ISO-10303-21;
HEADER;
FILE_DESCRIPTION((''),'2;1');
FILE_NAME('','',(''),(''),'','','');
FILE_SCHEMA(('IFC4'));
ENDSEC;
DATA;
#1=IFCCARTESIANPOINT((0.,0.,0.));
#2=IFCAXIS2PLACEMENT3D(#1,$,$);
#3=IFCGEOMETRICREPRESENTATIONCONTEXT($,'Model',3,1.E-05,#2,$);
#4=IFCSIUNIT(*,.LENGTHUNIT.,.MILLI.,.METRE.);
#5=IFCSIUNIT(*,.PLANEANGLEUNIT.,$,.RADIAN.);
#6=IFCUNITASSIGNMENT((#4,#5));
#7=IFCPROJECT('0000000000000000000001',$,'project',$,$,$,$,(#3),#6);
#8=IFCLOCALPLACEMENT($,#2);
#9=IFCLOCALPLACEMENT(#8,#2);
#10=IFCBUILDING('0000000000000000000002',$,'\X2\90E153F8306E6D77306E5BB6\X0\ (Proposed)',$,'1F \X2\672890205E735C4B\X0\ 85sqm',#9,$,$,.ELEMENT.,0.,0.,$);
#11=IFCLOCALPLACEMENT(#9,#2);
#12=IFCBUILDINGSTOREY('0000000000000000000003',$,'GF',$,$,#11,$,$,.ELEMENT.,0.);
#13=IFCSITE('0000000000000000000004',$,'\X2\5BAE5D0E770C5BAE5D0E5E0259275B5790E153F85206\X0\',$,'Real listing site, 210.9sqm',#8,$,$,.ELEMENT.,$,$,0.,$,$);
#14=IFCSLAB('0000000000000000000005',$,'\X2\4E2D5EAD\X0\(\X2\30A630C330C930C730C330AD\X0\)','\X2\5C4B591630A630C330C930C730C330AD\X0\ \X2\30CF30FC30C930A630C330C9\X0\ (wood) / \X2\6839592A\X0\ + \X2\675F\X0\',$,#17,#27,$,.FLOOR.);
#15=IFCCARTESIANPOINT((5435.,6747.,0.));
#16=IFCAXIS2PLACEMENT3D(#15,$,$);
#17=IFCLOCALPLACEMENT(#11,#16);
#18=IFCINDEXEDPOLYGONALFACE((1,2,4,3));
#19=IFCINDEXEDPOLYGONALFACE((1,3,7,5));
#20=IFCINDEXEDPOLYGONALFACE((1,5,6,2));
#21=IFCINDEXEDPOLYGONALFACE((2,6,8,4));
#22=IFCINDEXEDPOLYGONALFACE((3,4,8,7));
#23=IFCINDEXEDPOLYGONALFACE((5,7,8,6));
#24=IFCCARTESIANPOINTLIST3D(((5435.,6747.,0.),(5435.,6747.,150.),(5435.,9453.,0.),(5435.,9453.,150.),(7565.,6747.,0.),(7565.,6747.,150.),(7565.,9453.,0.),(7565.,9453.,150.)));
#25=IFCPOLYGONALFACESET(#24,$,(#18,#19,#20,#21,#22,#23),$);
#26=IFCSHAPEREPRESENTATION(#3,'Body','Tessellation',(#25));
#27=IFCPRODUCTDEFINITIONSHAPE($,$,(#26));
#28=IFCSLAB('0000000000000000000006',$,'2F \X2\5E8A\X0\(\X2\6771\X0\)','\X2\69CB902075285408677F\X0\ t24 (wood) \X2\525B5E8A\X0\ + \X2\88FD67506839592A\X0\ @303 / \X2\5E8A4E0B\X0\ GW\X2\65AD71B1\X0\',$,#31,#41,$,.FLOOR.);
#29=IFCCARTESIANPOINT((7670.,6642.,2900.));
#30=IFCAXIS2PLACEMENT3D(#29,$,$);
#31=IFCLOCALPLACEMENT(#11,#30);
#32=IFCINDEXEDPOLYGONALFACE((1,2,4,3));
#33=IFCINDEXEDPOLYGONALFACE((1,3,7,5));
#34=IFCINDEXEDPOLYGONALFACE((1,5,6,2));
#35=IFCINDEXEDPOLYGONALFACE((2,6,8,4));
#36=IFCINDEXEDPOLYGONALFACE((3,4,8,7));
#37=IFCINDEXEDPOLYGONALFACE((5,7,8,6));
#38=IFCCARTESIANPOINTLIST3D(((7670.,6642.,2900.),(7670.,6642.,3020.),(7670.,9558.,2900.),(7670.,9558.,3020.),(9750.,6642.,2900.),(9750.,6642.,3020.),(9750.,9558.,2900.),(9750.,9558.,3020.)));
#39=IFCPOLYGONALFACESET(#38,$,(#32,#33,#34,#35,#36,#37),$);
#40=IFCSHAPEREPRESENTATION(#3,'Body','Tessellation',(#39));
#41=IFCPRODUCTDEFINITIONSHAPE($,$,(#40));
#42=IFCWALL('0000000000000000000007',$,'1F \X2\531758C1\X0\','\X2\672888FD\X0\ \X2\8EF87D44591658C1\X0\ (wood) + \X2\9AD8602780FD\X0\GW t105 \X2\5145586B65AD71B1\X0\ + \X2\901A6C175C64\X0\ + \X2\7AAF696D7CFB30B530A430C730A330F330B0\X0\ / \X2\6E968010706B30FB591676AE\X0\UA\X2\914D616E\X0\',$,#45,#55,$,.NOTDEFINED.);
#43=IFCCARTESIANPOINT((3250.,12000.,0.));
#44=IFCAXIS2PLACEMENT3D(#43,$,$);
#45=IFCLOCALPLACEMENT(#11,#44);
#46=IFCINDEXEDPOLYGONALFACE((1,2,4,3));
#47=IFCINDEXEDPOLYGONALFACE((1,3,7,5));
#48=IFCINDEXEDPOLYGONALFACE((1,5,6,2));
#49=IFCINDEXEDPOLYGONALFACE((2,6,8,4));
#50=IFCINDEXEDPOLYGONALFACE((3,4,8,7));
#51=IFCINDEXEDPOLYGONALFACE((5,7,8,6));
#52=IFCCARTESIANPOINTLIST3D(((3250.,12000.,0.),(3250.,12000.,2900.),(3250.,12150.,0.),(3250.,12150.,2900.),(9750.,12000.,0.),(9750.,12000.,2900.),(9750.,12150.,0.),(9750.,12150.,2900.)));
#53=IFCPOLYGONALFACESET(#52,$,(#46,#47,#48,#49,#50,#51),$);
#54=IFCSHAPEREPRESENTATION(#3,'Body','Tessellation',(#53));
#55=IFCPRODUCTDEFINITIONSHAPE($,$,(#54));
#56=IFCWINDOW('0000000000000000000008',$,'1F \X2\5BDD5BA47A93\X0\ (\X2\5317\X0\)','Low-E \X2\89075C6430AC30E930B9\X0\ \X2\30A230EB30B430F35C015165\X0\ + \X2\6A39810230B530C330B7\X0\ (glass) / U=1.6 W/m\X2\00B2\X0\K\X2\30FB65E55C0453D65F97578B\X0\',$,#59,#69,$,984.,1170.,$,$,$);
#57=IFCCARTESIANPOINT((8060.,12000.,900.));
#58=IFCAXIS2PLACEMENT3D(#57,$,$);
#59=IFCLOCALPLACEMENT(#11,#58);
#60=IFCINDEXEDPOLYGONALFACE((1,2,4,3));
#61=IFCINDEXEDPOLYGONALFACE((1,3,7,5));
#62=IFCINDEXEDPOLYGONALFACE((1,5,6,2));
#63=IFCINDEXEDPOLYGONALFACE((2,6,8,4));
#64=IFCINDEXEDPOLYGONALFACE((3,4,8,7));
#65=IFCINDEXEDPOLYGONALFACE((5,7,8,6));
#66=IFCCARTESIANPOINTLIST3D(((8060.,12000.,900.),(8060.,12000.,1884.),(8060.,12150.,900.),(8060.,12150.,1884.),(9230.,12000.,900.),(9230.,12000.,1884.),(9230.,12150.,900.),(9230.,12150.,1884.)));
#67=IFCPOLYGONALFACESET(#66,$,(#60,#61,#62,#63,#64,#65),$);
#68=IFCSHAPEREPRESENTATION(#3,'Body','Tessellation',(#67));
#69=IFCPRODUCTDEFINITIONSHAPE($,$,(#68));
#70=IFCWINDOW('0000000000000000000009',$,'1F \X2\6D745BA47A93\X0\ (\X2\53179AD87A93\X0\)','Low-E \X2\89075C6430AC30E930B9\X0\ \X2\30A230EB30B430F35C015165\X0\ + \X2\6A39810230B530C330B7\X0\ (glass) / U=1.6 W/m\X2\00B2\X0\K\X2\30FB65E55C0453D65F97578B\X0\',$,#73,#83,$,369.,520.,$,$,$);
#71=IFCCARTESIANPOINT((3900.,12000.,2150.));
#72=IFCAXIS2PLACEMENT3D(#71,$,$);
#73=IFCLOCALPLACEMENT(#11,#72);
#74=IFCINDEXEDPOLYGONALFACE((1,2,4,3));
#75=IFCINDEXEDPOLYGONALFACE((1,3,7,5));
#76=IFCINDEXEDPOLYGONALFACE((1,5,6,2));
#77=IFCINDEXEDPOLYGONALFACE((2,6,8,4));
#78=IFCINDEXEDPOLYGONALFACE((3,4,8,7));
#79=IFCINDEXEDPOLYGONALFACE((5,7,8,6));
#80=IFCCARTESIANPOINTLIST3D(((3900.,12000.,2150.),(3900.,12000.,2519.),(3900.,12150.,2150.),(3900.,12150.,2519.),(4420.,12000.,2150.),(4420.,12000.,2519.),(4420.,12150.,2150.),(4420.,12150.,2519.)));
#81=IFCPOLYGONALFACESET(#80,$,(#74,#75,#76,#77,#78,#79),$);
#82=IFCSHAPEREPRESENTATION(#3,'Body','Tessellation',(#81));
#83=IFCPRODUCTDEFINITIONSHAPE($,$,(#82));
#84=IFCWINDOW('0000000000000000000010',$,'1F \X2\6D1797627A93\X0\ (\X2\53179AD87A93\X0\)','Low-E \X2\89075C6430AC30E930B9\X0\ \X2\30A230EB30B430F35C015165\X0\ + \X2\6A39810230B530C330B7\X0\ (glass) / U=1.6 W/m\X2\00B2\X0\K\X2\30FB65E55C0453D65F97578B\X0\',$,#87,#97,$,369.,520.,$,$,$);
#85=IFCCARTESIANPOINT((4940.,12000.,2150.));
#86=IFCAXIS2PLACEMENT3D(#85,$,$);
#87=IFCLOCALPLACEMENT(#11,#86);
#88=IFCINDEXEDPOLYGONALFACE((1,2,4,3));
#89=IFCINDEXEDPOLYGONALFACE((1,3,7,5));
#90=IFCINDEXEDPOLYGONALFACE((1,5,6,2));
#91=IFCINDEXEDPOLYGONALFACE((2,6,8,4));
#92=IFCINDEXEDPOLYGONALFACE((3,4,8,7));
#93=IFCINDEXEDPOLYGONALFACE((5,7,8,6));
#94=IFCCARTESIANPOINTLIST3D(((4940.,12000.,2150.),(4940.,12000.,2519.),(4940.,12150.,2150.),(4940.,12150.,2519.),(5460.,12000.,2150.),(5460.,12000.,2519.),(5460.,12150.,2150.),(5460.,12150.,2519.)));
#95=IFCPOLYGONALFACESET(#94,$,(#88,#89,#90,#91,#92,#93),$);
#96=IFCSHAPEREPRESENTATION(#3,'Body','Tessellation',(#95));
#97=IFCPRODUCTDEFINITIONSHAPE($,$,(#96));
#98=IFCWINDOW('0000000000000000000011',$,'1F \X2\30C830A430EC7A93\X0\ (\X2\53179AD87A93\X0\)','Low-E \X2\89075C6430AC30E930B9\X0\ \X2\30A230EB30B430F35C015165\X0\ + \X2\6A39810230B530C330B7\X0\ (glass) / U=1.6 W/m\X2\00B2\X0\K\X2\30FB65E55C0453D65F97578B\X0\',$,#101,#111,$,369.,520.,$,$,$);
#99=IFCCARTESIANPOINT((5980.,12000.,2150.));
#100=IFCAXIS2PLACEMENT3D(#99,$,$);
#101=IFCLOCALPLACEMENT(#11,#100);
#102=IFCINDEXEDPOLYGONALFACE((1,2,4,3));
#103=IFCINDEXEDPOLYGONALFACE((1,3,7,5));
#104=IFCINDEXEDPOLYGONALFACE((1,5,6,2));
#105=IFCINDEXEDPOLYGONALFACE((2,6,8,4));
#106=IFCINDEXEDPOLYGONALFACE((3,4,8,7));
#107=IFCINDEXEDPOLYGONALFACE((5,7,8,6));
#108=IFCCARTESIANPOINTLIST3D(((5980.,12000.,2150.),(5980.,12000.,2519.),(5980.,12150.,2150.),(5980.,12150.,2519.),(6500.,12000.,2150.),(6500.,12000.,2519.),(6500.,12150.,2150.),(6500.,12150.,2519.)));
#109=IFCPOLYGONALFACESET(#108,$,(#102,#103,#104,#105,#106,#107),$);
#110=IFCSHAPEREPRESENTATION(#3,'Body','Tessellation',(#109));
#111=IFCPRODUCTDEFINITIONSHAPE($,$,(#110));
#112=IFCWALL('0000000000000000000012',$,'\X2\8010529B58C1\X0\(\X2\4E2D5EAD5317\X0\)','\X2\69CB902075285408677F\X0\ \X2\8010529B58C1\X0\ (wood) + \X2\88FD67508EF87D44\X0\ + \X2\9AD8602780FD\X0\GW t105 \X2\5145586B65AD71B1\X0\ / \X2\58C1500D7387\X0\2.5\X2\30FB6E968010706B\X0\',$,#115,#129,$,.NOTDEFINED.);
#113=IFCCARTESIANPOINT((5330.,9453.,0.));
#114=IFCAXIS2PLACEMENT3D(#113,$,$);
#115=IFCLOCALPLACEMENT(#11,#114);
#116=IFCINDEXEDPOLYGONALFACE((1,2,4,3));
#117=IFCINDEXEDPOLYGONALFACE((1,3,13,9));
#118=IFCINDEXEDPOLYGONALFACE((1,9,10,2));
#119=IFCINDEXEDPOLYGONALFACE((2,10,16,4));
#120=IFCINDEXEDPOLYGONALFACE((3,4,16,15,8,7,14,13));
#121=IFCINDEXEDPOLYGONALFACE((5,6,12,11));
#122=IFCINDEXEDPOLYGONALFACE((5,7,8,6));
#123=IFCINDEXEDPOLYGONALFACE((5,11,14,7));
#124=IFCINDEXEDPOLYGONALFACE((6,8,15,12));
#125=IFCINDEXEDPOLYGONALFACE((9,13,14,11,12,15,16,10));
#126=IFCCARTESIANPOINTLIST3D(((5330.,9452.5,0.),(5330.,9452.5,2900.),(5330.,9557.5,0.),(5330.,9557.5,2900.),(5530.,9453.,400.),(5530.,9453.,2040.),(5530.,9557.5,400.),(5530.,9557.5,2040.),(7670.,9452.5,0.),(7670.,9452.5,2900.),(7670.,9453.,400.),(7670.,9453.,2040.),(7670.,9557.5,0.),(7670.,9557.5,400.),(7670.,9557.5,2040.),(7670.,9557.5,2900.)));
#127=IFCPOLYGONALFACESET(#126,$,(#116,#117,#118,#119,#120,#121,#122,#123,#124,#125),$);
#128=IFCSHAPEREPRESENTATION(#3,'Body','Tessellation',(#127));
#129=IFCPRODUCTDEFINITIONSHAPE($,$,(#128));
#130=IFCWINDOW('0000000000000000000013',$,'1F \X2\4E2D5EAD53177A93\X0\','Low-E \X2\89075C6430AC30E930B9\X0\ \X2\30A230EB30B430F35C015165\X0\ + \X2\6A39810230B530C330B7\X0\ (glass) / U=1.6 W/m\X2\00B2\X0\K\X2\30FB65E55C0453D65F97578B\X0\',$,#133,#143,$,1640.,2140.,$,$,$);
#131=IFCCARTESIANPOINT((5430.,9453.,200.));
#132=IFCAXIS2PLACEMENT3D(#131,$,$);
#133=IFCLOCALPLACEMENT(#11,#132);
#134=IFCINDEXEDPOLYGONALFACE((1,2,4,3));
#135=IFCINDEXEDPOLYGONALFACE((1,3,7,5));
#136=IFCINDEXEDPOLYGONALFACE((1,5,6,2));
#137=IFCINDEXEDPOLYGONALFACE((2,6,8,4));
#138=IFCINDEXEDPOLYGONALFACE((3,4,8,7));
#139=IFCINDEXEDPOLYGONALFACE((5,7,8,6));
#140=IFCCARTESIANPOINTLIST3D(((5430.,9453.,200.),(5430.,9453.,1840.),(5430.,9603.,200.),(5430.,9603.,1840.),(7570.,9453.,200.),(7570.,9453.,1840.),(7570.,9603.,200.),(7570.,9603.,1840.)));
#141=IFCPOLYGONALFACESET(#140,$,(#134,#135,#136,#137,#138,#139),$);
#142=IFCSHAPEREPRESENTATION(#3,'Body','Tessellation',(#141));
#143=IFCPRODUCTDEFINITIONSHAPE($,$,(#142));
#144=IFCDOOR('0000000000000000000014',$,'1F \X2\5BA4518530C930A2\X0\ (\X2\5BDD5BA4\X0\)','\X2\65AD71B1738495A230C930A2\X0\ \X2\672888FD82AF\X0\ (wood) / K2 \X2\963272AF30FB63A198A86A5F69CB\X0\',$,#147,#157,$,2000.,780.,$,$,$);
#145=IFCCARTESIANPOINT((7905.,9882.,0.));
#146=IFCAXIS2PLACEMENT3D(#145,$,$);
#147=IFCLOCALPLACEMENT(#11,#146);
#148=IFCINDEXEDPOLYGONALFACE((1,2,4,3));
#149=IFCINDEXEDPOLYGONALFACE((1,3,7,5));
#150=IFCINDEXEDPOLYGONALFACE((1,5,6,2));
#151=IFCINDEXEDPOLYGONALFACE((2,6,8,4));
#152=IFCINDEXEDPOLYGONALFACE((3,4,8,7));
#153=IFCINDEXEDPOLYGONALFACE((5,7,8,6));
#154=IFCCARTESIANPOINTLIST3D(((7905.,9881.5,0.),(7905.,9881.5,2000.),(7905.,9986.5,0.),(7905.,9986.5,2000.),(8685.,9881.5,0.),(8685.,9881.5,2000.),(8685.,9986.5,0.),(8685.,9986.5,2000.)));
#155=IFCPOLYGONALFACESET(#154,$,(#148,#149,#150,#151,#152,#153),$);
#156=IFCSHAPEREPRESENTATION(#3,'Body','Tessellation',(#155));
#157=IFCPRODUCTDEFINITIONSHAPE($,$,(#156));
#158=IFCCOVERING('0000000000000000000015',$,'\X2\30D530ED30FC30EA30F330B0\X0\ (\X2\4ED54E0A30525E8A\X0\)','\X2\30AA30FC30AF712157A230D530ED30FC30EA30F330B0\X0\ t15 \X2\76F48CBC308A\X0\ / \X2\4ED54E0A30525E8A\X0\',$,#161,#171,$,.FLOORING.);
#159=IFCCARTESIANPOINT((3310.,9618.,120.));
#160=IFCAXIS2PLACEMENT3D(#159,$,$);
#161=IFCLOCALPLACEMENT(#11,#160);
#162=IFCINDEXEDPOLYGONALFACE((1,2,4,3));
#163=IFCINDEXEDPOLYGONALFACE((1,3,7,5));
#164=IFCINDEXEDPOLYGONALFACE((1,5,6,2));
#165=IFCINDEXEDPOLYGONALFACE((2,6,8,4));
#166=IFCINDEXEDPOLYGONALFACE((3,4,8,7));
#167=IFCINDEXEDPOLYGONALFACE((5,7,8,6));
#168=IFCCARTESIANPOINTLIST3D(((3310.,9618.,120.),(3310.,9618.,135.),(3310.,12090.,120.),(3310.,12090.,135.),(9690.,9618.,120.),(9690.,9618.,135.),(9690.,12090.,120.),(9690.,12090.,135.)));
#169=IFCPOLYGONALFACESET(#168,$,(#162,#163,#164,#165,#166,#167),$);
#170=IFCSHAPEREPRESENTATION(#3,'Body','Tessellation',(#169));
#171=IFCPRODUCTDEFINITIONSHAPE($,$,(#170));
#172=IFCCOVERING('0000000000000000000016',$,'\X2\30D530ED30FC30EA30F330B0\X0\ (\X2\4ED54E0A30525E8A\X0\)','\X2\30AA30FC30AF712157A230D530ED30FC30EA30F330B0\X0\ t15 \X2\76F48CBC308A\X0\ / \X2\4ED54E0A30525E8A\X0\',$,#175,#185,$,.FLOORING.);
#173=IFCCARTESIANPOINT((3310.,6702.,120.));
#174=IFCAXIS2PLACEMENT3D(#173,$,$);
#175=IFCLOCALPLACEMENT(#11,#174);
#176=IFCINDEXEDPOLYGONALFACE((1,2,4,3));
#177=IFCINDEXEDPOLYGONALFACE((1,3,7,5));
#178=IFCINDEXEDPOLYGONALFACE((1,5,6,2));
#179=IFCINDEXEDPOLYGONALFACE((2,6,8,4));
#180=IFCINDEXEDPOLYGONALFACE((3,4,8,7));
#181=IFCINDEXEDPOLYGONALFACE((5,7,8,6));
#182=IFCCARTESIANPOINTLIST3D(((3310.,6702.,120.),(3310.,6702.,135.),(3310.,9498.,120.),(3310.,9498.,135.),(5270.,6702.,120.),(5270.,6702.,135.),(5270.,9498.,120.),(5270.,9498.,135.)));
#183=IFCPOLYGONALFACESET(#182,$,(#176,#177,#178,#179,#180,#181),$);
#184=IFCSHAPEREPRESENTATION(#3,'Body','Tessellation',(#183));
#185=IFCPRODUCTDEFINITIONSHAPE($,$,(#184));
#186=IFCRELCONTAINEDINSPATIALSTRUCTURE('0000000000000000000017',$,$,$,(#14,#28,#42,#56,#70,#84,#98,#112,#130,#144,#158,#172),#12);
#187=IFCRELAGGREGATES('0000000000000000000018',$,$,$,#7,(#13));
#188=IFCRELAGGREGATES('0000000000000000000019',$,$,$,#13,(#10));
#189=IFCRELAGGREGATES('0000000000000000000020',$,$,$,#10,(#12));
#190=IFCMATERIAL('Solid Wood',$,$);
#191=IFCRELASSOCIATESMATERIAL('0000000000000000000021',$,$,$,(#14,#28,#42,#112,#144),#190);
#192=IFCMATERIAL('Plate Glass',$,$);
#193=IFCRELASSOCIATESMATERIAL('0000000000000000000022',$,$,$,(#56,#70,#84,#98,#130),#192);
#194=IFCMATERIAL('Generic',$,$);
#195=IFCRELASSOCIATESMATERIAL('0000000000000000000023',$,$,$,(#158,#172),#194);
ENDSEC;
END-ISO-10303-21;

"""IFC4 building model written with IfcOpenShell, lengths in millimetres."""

from ifc_helpers import new_model, si_unit, frame, frame_2d, origin, place, context, project, spatial, rectangle, extrude, material, element, fill, save


model = new_model("IFC4")

# Units and contexts
model_context = context("Model", 3, precision=1e-05, world=origin())
ifc_project = project(units=[si_unit("LENGTHUNIT", "METRE", prefix="MILLI"), si_unit("PLANEANGLEUNIT", "RADIAN")], contexts=[model_context])

# Site, building, storey
site_placement = place(None, origin())
site = spatial("IfcSite", under=ifc_project, at=site_placement, Name="宮崎県宮崎市大字郡司分", ObjectType="Real listing site, 210.9sqm", CompositionType="ELEMENT", RefElevation=0.0)
building_placement = place(site_placement, origin())
building = spatial("IfcBuilding", under=site, at=building_placement, Name="郡司の海の家 (Proposed)", ObjectType="1F 木造平屋 85sqm", CompositionType="ELEMENT", ElevationOfRefHeight=0.0, ElevationOfTerrain=0.0)
storey_placement = place(building_placement, origin())
storey = spatial("IfcBuildingStorey", under=building, at=storey_placement, Name="GF", CompositionType="ELEMENT", Elevation=0.0)

# Slabs
ifc_material_1 = material(Name="Solid Wood")
slab_1_placement = place(storey_placement, frame((5435.0, 6747.0, 0.0)))
element("IfcSlab", 1, at=slab_1_placement, inside=storey, material=ifc_material_1, Name="中庭(ウッドデッキ)", Description="屋外ウッドデッキ ハードウッド (wood) / 根太 + 束", PredefinedType="FLOOR", context=model_context, shape_type="SweptSolid", body=[
    extrude(rectangle(XDim=2130.0, YDim=2706.0, at=frame_2d((1065.0, 1353.0))), frame((5435.0, 6747.0, 0.0)), (0.0, 0.0, 1.0), 150.0),
])
slab_2_placement = place(storey_placement, frame((7670.0, 6642.0, 2900.0)))
element("IfcSlab", 2, at=slab_2_placement, inside=storey, material=ifc_material_1, Name="2F 床(東)", Description="構造用合板 t24 (wood) 剛床 + 製材根太 @303 / 床下 GW断熱", PredefinedType="FLOOR", context=model_context, shape_type="SweptSolid", body=[
    extrude(rectangle(XDim=2080.0, YDim=2916.0, at=frame_2d((1040.0, 1458.0))), frame((7670.0, 6642.0, 2900.0)), (0.0, 0.0, 1.0), 120.0),
])

# Wall, openings, windows
wall_1_placement = place(storey_placement, frame((3250.0, 12000.0, 0.0)))
wall_1 = element("IfcWall", 3, at=wall_1_placement, inside=storey, material=ifc_material_1, Name="1F 北壁", Description="木製 軸組外壁 (wood) + 高性能GW t105 充填断熱 + 通気層 + 窯業系サイディング / 準耐火・外皮UA配慮", PredefinedType="NOTDEFINED", context=model_context, shape_type="SweptSolid", body=[
    extrude(rectangle(XDim=6500.0, YDim=150.0, at=frame_2d((3250.0, 75.0))), frame((3250.0, 12000.0, 0.0)), (0.0, 0.0, 1.0), 2900.0),
])
opening_1_placement = place(storey_placement, frame((8060.0, 12000.0, 900.0)))
opening_1 = element("IfcOpeningElement", 4, at=opening_1_placement, cuts=wall_1, PredefinedType="NOTDEFINED", context=model_context, shape_type="SweptSolid", body=[
    extrude(rectangle(XDim=1170.0, YDim=150.0, at=frame_2d((585.0, 75.0))), frame((8060.0, 12000.0, 900.0)), (0.0, 0.0, 1.0), 984.0),
])
opening_2_placement = place(storey_placement, frame((3900.0, 12000.0, 2150.0)))
opening_2 = element("IfcOpeningElement", 5, at=opening_2_placement, cuts=wall_1, PredefinedType="NOTDEFINED", context=model_context, shape_type="SweptSolid", body=[
    extrude(rectangle(XDim=520.0, YDim=150.0, at=frame_2d((260.0, 75.0))), frame((3900.0, 12000.0, 2150.0)), (0.0, 0.0, 1.0), 369.0),
])
opening_3_placement = place(storey_placement, frame((4940.0, 12000.0, 2150.0)))
opening_3 = element("IfcOpeningElement", 6, at=opening_3_placement, cuts=wall_1, PredefinedType="NOTDEFINED", context=model_context, shape_type="SweptSolid", body=[
    extrude(rectangle(XDim=520.0, YDim=150.0, at=frame_2d((260.0, 75.0))), frame((4940.0, 12000.0, 2150.0)), (0.0, 0.0, 1.0), 369.0),
])
opening_4_placement = place(storey_placement, frame((5980.0, 12000.0, 2150.0)))
opening_4 = element("IfcOpeningElement", 7, at=opening_4_placement, cuts=wall_1, PredefinedType="NOTDEFINED", context=model_context, shape_type="SweptSolid", body=[
    extrude(rectangle(XDim=520.0, YDim=150.0, at=frame_2d((260.0, 75.0))), frame((5980.0, 12000.0, 2150.0)), (0.0, 0.0, 1.0), 369.0),
])
ifc_material_2 = material(Name="Plate Glass")
window_1_placement = place(storey_placement, frame((8060.0, 12000.0, 900.0)))
window_1 = element("IfcWindow", 8, at=window_1_placement, inside=storey, material=ifc_material_2, Name="1F 寝室窓 (北)", Description="Low-E 複層ガラス アルゴン封入 + 樹脂サッシ (glass) / U=1.6 W/m²K・日射取得型", OverallHeight=984.0, OverallWidth=1170.0, context=model_context, shape_type="SweptSolid", body=[
    extrude(rectangle(XDim=1170.0, YDim=150.0, at=frame_2d((585.0, 75.0))), frame((8060.0, 12000.0, 900.0)), (0.0, 0.0, 1.0), 984.0),
])
fill(opening_1, window_1)
window_2_placement = place(storey_placement, frame((3900.0, 12000.0, 2150.0)))
window_2 = element("IfcWindow", 9, at=window_2_placement, inside=storey, material=ifc_material_2, Name="1F 浴室窓 (北高窓)", Description="Low-E 複層ガラス アルゴン封入 + 樹脂サッシ (glass) / U=1.6 W/m²K・日射取得型", OverallHeight=369.0, OverallWidth=520.0, context=model_context, shape_type="SweptSolid", body=[
    extrude(rectangle(XDim=520.0, YDim=150.0, at=frame_2d((260.0, 75.0))), frame((3900.0, 12000.0, 2150.0)), (0.0, 0.0, 1.0), 369.0),
])
fill(opening_2, window_2)
window_3_placement = place(storey_placement, frame((4940.0, 12000.0, 2150.0)))
window_3 = element("IfcWindow", 10, at=window_3_placement, inside=storey, material=ifc_material_2, Name="1F 洗面窓 (北高窓)", Description="Low-E 複層ガラス アルゴン封入 + 樹脂サッシ (glass) / U=1.6 W/m²K・日射取得型", OverallHeight=369.0, OverallWidth=520.0, context=model_context, shape_type="SweptSolid", body=[
    extrude(rectangle(XDim=520.0, YDim=150.0, at=frame_2d((260.0, 75.0))), frame((4940.0, 12000.0, 2150.0)), (0.0, 0.0, 1.0), 369.0),
])
fill(opening_3, window_3)
window_4_placement = place(storey_placement, frame((5980.0, 12000.0, 2150.0)))
window_4 = element("IfcWindow", 11, at=window_4_placement, inside=storey, material=ifc_material_2, Name="1F トイレ窓 (北高窓)", Description="Low-E 複層ガラス アルゴン封入 + 樹脂サッシ (glass) / U=1.6 W/m²K・日射取得型", OverallHeight=369.0, OverallWidth=520.0, context=model_context, shape_type="SweptSolid", body=[
    extrude(rectangle(XDim=520.0, YDim=150.0, at=frame_2d((260.0, 75.0))), frame((5980.0, 12000.0, 2150.0)), (0.0, 0.0, 1.0), 369.0),
])
fill(opening_4, window_4)

# Wall, opening, window
wall_2_placement = place(storey_placement, frame((5330.0, 9453.0, 0.0)))
wall_2 = element("IfcWall", 12, at=wall_2_placement, inside=storey, material=ifc_material_1, Name="耐力壁(中庭北)", Description="構造用合板 耐力壁 (wood) + 製材軸組 + 高性能GW t105 充填断熱 / 壁倍率2.5・準耐火", PredefinedType="NOTDEFINED", context=model_context, shape_type="SweptSolid", body=[
    extrude(rectangle(XDim=2340.0, YDim=105.0, at=frame_2d((1170.0, 52.0))), frame((5330.0, 9453.0, 0.0)), (0.0, 0.0, 1.0), 2900.0),
])
opening_5_placement = place(storey_placement, frame((5430.0, 9453.0, 200.0)))
opening_5 = element("IfcOpeningElement", 13, at=opening_5_placement, cuts=wall_2, PredefinedType="NOTDEFINED", context=model_context, shape_type="SweptSolid", body=[
    extrude(rectangle(XDim=2140.0, YDim=150.0, at=frame_2d((1070.0, 75.0))), frame((5430.0, 9453.0, 200.0)), (0.0, 0.0, 1.0), 1640.0),
])
window_5_placement = place(storey_placement, frame((5430.0, 9453.0, 200.0)))
window_5 = element("IfcWindow", 14, at=window_5_placement, inside=storey, material=ifc_material_2, Name="1F 中庭北窓", Description="Low-E 複層ガラス アルゴン封入 + 樹脂サッシ (glass) / U=1.6 W/m²K・日射取得型", OverallHeight=1640.0, OverallWidth=2140.0, context=model_context, shape_type="SweptSolid", body=[
    extrude(rectangle(XDim=2140.0, YDim=150.0, at=frame_2d((1070.0, 75.0))), frame((5430.0, 9453.0, 200.0)), (0.0, 0.0, 1.0), 1640.0),
])
fill(opening_5, window_5)

# Door
door_1_placement = place(storey_placement, frame((7905.0, 9882.0, 0.0)))
element("IfcDoor", 15, at=door_1_placement, inside=storey, material=ifc_material_1, Name="1F 室内ドア (寝室)", Description="断熱玄関ドア 木製芯 (wood) / K2 防犯・採風機構", OverallHeight=2000.0, OverallWidth=780.0, context=model_context, shape_type="SweptSolid", body=[
    extrude(rectangle(XDim=780.0, YDim=105.0, at=frame_2d((390.0, 52.0))), frame((7905.0, 9882.0, 0.0)), (0.0, 0.0, 1.0), 2000.0),
])

# Coverings
ifc_material_3 = material(Name="Generic")
covering_1_placement = place(storey_placement, frame((3310.0, 9618.0, 120.0)))
element("IfcCovering", 16, at=covering_1_placement, inside=storey, material=ifc_material_3, Name="フローリング (仕上げ床)", Description="オーク無垢フローリング t15 直貼り / 仕上げ床", PredefinedType="FLOORING", context=model_context, shape_type="SweptSolid", body=[
    extrude(rectangle(XDim=6380.0, YDim=2472.0, at=frame_2d((3190.0, 1236.0))), frame((3310.0, 9618.0, 120.0)), (0.0, 0.0, 1.0), 15.0),
])
covering_2_placement = place(storey_placement, frame((3310.0, 6702.0, 120.0)))
element("IfcCovering", 17, at=covering_2_placement, inside=storey, material=ifc_material_3, Name="フローリング (仕上げ床)", Description="オーク無垢フローリング t15 直貼り / 仕上げ床", PredefinedType="FLOORING", context=model_context, shape_type="SweptSolid", body=[
    extrude(rectangle(XDim=1960.0, YDim=2796.0, at=frame_2d((980.0, 1398.0))), frame((3310.0, 6702.0, 120.0)), (0.0, 0.0, 1.0), 15.0),
])

save(model, "model.ifc")
